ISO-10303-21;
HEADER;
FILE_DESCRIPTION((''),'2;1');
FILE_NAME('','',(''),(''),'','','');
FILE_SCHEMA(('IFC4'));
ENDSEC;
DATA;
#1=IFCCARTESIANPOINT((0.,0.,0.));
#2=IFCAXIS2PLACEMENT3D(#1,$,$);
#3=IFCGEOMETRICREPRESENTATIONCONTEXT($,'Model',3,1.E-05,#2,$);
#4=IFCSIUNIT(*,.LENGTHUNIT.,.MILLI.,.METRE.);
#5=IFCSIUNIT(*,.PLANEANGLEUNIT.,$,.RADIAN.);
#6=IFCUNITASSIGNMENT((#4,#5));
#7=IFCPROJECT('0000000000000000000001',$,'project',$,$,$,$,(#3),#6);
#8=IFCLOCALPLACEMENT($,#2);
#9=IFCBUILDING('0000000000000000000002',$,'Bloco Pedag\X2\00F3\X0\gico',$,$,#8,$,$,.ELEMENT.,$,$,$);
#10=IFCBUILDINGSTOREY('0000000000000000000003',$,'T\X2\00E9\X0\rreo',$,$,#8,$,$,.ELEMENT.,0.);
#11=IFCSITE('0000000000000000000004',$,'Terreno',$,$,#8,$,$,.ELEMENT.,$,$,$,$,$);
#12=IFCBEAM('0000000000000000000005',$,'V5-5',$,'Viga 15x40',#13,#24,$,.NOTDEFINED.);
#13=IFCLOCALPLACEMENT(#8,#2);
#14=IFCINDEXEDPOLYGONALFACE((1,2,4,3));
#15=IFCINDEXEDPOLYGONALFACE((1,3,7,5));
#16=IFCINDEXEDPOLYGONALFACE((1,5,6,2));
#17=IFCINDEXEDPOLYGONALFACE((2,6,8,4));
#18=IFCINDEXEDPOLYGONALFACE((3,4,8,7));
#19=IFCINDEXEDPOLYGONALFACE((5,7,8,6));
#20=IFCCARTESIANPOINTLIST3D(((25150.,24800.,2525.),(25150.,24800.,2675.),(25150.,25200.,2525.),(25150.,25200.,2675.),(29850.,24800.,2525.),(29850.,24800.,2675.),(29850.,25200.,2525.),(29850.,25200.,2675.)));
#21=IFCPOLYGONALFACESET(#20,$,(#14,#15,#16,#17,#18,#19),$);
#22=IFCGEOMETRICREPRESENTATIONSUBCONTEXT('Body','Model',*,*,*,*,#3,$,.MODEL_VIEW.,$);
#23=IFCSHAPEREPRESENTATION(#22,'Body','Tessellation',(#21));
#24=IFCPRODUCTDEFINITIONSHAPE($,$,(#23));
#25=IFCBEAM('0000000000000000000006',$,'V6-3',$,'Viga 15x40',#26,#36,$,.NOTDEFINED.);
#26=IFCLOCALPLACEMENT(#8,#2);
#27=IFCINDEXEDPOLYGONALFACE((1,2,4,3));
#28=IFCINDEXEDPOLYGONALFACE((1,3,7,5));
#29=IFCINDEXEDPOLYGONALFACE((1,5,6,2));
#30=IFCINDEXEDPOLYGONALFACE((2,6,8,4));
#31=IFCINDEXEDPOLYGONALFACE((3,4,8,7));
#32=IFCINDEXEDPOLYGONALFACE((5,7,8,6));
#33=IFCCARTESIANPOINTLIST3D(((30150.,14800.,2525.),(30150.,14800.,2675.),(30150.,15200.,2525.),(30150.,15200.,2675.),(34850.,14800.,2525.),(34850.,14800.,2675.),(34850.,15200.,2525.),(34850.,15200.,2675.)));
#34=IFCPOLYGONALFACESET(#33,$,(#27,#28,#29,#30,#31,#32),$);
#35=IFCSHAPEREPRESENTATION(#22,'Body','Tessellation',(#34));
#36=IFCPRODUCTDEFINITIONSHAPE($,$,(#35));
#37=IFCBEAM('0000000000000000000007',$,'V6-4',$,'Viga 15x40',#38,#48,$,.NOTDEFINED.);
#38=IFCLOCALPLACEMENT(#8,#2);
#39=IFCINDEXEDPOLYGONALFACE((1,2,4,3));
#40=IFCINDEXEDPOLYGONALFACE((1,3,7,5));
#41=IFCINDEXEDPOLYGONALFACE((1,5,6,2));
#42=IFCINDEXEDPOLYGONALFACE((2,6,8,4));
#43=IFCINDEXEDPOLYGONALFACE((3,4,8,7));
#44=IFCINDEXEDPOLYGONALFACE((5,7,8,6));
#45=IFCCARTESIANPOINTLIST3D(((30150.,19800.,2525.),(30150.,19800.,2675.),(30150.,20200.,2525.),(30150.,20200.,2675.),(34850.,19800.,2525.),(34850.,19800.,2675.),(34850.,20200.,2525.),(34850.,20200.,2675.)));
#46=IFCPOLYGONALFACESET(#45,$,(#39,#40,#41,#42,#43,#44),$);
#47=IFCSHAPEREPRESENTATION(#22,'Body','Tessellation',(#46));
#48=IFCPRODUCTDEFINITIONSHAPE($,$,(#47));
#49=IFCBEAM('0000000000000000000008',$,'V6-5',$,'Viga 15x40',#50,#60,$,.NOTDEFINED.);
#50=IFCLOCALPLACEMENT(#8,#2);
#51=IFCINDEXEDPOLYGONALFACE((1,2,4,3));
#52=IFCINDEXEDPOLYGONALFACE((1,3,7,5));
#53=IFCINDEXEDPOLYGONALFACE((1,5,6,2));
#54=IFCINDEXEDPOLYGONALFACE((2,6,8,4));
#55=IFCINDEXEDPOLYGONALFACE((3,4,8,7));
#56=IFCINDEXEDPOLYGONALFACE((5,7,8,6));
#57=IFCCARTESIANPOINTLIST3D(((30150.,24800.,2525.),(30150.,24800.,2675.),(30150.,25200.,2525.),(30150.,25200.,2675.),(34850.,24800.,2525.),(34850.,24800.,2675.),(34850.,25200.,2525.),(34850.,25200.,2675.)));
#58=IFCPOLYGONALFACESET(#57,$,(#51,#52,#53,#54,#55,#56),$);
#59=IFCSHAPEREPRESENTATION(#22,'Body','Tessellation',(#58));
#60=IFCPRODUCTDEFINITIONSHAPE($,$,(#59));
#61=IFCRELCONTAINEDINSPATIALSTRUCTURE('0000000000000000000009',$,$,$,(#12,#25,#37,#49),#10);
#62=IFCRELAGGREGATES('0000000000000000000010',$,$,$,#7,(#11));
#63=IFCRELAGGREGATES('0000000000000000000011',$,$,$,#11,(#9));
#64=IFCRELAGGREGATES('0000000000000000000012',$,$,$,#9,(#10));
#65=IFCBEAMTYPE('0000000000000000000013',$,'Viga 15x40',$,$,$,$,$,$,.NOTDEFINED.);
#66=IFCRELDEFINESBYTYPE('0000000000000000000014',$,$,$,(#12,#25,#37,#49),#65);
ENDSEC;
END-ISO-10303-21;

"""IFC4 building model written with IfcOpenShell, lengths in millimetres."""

from ifc_helpers import new_model, si_unit, frame, origin, origin_2d, place, context, subcontext, project, spatial, rectangle, extrude, type_object, element, save


model = new_model("IFC4")

# Units and contexts
model_context = context("Model", 3, precision=1e-05, world=origin())
body_context = subcontext(model_context, "Body", "Model", "MODEL_VIEW")
ifc_project = project(units=[si_unit("LENGTHUNIT", "METRE", prefix="MILLI"), si_unit("PLANEANGLEUNIT", "RADIAN")], contexts=[model_context])

# Site, building, storey
placement = place(None, origin())
site = spatial("IfcSite", under=ifc_project, at=placement, Name="Terreno", CompositionType="ELEMENT")
building = spatial("IfcBuilding", under=site, at=placement, Name="Bloco Pedagógico", CompositionType="ELEMENT")
storey = spatial("IfcBuildingStorey", under=building, at=placement, Name="Térreo", CompositionType="ELEMENT", Elevation=0.0)

# Beams
beam_type = type_object("IfcBeamType", Name="Viga 15x40", PredefinedType="NOTDEFINED")
for number, where, z_axis, x_axis, name in (
    (1, (25150.0, 25000.0, 2600.0), (1.0, 0.0, 0.0), (0.0, 1.0, 0.0), "V5-5"),
    (2, (30150.0, 15000.0, 2600.0), (1.0, 0.0, 0.0), (0.0, 1.0, 0.0), "V6-3"),
    (3, (30150.0, 20000.0, 2600.0), (1.0, 0.0, 0.0), (0.0, 1.0, 0.0), "V6-4"),
    (4, (30150.0, 25000.0, 2600.0), (1.0, 0.0, 0.0), (0.0, 1.0, 0.0), "V6-5"),
):
    element("IfcBeam", number, at=place(None, frame(where, z_axis=z_axis, x_axis=x_axis)), inside=storey, type_object=beam_type, Name=name, ObjectType="Viga 15x40", PredefinedType="NOTDEFINED", context=body_context, shape_type="SweptSolid", body=[
        extrude(rectangle(XDim=400.0, YDim=150.0, at=origin_2d()), None, (0.0, 0.0, 1.0), 4700.0),
    ])

save(model, "model.ifc")
